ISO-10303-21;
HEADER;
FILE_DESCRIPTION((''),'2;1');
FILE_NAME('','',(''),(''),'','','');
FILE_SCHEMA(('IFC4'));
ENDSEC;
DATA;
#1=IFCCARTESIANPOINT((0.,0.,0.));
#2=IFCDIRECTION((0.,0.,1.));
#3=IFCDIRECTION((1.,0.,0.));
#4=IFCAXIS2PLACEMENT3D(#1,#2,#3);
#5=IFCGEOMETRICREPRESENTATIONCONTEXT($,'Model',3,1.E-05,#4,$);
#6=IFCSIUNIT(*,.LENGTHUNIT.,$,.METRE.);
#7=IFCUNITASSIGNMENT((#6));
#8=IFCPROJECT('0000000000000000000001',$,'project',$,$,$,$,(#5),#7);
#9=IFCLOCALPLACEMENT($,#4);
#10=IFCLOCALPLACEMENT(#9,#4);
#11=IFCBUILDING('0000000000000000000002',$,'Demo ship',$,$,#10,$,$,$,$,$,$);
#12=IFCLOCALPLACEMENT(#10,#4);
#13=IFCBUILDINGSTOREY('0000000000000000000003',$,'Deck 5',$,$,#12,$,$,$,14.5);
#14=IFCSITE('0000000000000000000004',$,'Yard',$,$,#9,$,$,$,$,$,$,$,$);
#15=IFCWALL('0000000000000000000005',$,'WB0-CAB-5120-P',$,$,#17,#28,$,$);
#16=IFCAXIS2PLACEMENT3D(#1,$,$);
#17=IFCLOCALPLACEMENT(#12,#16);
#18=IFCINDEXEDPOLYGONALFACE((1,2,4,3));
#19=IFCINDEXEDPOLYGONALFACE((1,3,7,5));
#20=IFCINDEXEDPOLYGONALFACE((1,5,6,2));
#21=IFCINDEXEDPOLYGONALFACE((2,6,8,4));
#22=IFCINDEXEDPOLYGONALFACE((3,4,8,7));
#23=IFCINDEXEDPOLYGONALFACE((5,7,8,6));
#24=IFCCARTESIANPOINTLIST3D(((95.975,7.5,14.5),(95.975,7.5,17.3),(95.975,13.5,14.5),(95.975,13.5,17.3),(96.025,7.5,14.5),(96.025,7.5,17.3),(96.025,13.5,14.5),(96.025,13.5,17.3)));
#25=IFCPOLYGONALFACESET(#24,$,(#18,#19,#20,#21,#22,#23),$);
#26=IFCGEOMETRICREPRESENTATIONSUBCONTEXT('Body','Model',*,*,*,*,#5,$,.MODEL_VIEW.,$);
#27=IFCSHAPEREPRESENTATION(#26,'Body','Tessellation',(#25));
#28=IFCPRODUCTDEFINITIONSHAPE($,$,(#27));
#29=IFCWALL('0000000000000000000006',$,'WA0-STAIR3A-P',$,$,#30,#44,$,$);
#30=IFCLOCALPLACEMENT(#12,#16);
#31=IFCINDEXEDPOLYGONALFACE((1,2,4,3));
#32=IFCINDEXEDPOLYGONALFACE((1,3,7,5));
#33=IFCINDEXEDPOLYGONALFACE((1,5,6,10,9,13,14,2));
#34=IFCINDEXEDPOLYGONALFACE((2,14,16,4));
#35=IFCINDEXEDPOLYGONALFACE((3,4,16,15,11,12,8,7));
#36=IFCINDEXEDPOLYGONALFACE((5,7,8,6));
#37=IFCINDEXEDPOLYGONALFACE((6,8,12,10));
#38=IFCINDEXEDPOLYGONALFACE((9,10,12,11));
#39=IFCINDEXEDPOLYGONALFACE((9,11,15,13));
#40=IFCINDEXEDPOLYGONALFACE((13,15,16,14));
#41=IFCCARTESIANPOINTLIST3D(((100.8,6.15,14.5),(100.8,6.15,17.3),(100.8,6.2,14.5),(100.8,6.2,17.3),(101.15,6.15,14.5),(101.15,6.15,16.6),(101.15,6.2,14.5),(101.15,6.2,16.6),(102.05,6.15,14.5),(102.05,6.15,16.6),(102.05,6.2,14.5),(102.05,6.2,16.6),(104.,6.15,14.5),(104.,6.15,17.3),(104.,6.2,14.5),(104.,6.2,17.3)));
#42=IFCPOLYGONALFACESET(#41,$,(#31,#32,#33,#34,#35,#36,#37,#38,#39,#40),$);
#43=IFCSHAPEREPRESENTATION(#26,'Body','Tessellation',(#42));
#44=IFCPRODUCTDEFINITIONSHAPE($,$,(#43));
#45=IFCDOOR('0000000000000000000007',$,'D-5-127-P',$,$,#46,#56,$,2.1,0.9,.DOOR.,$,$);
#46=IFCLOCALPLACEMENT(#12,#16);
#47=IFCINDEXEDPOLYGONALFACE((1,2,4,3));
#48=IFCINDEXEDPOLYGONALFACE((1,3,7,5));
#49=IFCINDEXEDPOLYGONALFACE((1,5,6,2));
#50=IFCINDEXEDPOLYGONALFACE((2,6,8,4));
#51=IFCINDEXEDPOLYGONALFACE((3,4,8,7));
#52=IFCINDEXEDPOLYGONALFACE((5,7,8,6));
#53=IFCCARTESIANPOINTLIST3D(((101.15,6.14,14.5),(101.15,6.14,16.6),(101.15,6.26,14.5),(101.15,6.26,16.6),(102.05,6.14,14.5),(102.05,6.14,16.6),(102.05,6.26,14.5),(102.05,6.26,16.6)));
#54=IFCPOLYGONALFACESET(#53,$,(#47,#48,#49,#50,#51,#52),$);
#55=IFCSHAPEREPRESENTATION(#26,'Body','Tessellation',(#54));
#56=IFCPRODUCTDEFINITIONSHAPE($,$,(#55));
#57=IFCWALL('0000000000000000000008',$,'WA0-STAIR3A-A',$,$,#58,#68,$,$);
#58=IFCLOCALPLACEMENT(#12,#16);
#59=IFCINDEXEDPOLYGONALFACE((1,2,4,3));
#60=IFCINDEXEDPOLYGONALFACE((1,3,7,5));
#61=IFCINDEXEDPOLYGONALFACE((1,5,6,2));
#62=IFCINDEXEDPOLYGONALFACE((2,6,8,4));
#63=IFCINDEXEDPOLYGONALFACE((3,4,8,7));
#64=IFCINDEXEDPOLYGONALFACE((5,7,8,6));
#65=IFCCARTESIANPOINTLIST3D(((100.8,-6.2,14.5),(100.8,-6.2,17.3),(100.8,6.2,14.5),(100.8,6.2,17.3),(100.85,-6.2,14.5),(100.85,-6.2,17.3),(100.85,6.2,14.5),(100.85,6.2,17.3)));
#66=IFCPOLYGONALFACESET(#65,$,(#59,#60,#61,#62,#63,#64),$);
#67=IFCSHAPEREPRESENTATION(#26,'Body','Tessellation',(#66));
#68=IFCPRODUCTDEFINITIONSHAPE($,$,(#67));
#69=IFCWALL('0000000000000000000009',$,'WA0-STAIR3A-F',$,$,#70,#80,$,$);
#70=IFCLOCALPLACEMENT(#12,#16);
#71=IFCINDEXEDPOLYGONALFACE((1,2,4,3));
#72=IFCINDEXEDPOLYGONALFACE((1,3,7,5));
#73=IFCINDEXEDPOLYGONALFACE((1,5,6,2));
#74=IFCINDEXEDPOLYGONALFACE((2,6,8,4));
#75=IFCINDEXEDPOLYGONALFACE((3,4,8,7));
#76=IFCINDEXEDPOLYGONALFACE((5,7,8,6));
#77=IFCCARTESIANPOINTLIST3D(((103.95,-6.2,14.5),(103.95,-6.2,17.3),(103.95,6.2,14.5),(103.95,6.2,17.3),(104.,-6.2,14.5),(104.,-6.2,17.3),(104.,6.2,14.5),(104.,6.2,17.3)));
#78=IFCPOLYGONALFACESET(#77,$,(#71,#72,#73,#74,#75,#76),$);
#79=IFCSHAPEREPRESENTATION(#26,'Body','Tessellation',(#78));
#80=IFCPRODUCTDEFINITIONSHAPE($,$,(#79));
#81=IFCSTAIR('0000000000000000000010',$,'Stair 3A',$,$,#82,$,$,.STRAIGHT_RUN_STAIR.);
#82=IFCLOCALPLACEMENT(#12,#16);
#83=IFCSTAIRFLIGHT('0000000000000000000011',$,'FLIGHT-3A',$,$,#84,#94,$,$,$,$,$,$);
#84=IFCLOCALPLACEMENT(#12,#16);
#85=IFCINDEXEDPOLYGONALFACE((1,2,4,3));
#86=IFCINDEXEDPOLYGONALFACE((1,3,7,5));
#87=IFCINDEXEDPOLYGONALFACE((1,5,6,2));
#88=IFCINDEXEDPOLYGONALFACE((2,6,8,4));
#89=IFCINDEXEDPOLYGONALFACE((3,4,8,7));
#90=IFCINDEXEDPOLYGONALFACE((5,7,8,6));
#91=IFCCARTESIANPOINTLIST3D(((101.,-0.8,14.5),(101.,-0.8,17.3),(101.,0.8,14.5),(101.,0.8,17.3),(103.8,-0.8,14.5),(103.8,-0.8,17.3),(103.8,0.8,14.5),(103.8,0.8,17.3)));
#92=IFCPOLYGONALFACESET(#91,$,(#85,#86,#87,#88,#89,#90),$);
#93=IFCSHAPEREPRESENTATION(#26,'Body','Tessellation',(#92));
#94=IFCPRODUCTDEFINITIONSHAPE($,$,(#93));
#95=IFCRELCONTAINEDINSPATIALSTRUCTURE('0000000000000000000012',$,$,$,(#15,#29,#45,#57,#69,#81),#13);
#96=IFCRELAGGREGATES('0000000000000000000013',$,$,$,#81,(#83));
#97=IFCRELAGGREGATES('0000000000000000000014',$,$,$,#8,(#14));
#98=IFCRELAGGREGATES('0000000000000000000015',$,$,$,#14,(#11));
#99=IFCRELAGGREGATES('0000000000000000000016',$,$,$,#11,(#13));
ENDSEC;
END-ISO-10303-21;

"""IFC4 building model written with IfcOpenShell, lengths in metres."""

from ifc_helpers import new_model, si_unit, frame, frame_2d, origin, origin_with_axes, place, context, subcontext, project, spatial, rectangle, extrude, element, fill, aggregate, save


model = new_model("IFC4")

# Units and contexts
model_context = context("Model", 3, precision=1e-05, world=origin_with_axes())
body_context = subcontext(model_context, "Body", "Model", "MODEL_VIEW")
ifc_project = project(units=[si_unit("LENGTHUNIT", "METRE")], contexts=[model_context])

# Site, building, storey
site_placement = place(None, origin_with_axes())
site = spatial("IfcSite", under=ifc_project, at=site_placement, Name="Yard")
building_placement = place(site_placement, origin_with_axes())
building = spatial("IfcBuilding", under=site, at=building_placement, Name="Demo ship")
storey_placement = place(building_placement, origin_with_axes())
storey = spatial("IfcBuildingStorey", under=building, at=storey_placement, Name="Deck 5", Elevation=14.5)

# Wall
wall_1_placement = place(storey_placement, frame((95.975, 7.5, 14.5), z_axis=(0.0, 0.0, 1.0), x_axis=(1.0, 0.0, 0.0)))
element("IfcWall", 1, at=wall_1_placement, inside=storey, Name="WB0-CAB-5120-P", context=body_context, shape_type="SweptSolid", body=[
    extrude(rectangle(XDim=0.05, YDim=6.0, at=frame_2d((0.025, 3.0))), origin(), (0.0, 0.0, 1.0), 2.8),
])

# Wall, opening, door
wall_2_placement = place(storey_placement, frame((100.8, 6.15, 14.5), z_axis=(0.0, 0.0, 1.0), x_axis=(1.0, 0.0, 0.0)))
wall_2 = element("IfcWall", 2, at=wall_2_placement, inside=storey, Name="WA0-STAIR3A-P", context=body_context, shape_type="SweptSolid", body=[
    extrude(rectangle(XDim=3.2, YDim=0.05, at=frame_2d((1.6, 0.025))), origin(), (0.0, 0.0, 1.0), 2.8),
])
opening_1_placement = place(None, frame((101.15, 6.14, 14.5), z_axis=(0.0, 0.0, 1.0), x_axis=(1.0, 0.0, 0.0)))
opening_1 = element("IfcOpeningElement", 3, at=opening_1_placement, cuts=wall_2, context=body_context, shape_type="SweptSolid", body=[
    extrude(rectangle(XDim=0.9, YDim=0.12, at=frame_2d((0.45, 0.06))), origin(), (0.0, 0.0, 1.0), 2.1),
])
door_1_placement = place(storey_placement, frame((101.15, 6.14, 14.5), z_axis=(0.0, 0.0, 1.0), x_axis=(1.0, 0.0, 0.0)))
door_1 = element("IfcDoor", 4, at=door_1_placement, inside=storey, Name="D-5-127-P", OverallHeight=2.1, OverallWidth=0.9, PredefinedType="DOOR", context=body_context, shape_type="SweptSolid", body=[
    extrude(rectangle(XDim=0.9, YDim=0.12, at=frame_2d((0.45, 0.06))), origin(), (0.0, 0.0, 1.0), 2.1),
])
fill(opening_1, door_1)

# Walls
for number, where, z_axis, x_axis, name in (
    (5, (100.8, -6.2, 14.5), (0.0, 0.0, 1.0), (1.0, 0.0, 0.0), "WA0-STAIR3A-A"),
    (6, (103.95, -6.2, 14.5), (0.0, 0.0, 1.0), (1.0, 0.0, 0.0), "WA0-STAIR3A-F"),
):
    element("IfcWall", number, at=place(storey_placement, frame(where, z_axis=z_axis, x_axis=x_axis)), inside=storey, Name=name, context=body_context, shape_type="SweptSolid", body=[
        extrude(rectangle(XDim=0.05, YDim=12.4, at=frame_2d((0.025, 6.2))), origin(), (0.0, 0.0, 1.0), 2.8),
    ])

# Stair, stair flight
stair_placement = place(storey_placement, frame((101.0, -0.8, 14.5), z_axis=(0.0, 0.0, 1.0), x_axis=(1.0, 0.0, 0.0)))
stair = element("IfcStair", 7, at=stair_placement, inside=storey, Name="Stair 3A", PredefinedType="STRAIGHT_RUN_STAIR")
stair_flight_placement = place(stair_placement, origin_with_axes())
stair_flight = element("IfcStairFlight", 8, at=stair_flight_placement, Name="FLIGHT-3A", context=body_context, shape_type="SweptSolid", body=[
    extrude(rectangle(XDim=2.8, YDim=1.6, at=frame_2d((1.4, 0.8))), origin(), (0.0, 0.0, 1.0), 2.8),
])
aggregate(stair, [stair_flight])

save(model, "model.ifc")
